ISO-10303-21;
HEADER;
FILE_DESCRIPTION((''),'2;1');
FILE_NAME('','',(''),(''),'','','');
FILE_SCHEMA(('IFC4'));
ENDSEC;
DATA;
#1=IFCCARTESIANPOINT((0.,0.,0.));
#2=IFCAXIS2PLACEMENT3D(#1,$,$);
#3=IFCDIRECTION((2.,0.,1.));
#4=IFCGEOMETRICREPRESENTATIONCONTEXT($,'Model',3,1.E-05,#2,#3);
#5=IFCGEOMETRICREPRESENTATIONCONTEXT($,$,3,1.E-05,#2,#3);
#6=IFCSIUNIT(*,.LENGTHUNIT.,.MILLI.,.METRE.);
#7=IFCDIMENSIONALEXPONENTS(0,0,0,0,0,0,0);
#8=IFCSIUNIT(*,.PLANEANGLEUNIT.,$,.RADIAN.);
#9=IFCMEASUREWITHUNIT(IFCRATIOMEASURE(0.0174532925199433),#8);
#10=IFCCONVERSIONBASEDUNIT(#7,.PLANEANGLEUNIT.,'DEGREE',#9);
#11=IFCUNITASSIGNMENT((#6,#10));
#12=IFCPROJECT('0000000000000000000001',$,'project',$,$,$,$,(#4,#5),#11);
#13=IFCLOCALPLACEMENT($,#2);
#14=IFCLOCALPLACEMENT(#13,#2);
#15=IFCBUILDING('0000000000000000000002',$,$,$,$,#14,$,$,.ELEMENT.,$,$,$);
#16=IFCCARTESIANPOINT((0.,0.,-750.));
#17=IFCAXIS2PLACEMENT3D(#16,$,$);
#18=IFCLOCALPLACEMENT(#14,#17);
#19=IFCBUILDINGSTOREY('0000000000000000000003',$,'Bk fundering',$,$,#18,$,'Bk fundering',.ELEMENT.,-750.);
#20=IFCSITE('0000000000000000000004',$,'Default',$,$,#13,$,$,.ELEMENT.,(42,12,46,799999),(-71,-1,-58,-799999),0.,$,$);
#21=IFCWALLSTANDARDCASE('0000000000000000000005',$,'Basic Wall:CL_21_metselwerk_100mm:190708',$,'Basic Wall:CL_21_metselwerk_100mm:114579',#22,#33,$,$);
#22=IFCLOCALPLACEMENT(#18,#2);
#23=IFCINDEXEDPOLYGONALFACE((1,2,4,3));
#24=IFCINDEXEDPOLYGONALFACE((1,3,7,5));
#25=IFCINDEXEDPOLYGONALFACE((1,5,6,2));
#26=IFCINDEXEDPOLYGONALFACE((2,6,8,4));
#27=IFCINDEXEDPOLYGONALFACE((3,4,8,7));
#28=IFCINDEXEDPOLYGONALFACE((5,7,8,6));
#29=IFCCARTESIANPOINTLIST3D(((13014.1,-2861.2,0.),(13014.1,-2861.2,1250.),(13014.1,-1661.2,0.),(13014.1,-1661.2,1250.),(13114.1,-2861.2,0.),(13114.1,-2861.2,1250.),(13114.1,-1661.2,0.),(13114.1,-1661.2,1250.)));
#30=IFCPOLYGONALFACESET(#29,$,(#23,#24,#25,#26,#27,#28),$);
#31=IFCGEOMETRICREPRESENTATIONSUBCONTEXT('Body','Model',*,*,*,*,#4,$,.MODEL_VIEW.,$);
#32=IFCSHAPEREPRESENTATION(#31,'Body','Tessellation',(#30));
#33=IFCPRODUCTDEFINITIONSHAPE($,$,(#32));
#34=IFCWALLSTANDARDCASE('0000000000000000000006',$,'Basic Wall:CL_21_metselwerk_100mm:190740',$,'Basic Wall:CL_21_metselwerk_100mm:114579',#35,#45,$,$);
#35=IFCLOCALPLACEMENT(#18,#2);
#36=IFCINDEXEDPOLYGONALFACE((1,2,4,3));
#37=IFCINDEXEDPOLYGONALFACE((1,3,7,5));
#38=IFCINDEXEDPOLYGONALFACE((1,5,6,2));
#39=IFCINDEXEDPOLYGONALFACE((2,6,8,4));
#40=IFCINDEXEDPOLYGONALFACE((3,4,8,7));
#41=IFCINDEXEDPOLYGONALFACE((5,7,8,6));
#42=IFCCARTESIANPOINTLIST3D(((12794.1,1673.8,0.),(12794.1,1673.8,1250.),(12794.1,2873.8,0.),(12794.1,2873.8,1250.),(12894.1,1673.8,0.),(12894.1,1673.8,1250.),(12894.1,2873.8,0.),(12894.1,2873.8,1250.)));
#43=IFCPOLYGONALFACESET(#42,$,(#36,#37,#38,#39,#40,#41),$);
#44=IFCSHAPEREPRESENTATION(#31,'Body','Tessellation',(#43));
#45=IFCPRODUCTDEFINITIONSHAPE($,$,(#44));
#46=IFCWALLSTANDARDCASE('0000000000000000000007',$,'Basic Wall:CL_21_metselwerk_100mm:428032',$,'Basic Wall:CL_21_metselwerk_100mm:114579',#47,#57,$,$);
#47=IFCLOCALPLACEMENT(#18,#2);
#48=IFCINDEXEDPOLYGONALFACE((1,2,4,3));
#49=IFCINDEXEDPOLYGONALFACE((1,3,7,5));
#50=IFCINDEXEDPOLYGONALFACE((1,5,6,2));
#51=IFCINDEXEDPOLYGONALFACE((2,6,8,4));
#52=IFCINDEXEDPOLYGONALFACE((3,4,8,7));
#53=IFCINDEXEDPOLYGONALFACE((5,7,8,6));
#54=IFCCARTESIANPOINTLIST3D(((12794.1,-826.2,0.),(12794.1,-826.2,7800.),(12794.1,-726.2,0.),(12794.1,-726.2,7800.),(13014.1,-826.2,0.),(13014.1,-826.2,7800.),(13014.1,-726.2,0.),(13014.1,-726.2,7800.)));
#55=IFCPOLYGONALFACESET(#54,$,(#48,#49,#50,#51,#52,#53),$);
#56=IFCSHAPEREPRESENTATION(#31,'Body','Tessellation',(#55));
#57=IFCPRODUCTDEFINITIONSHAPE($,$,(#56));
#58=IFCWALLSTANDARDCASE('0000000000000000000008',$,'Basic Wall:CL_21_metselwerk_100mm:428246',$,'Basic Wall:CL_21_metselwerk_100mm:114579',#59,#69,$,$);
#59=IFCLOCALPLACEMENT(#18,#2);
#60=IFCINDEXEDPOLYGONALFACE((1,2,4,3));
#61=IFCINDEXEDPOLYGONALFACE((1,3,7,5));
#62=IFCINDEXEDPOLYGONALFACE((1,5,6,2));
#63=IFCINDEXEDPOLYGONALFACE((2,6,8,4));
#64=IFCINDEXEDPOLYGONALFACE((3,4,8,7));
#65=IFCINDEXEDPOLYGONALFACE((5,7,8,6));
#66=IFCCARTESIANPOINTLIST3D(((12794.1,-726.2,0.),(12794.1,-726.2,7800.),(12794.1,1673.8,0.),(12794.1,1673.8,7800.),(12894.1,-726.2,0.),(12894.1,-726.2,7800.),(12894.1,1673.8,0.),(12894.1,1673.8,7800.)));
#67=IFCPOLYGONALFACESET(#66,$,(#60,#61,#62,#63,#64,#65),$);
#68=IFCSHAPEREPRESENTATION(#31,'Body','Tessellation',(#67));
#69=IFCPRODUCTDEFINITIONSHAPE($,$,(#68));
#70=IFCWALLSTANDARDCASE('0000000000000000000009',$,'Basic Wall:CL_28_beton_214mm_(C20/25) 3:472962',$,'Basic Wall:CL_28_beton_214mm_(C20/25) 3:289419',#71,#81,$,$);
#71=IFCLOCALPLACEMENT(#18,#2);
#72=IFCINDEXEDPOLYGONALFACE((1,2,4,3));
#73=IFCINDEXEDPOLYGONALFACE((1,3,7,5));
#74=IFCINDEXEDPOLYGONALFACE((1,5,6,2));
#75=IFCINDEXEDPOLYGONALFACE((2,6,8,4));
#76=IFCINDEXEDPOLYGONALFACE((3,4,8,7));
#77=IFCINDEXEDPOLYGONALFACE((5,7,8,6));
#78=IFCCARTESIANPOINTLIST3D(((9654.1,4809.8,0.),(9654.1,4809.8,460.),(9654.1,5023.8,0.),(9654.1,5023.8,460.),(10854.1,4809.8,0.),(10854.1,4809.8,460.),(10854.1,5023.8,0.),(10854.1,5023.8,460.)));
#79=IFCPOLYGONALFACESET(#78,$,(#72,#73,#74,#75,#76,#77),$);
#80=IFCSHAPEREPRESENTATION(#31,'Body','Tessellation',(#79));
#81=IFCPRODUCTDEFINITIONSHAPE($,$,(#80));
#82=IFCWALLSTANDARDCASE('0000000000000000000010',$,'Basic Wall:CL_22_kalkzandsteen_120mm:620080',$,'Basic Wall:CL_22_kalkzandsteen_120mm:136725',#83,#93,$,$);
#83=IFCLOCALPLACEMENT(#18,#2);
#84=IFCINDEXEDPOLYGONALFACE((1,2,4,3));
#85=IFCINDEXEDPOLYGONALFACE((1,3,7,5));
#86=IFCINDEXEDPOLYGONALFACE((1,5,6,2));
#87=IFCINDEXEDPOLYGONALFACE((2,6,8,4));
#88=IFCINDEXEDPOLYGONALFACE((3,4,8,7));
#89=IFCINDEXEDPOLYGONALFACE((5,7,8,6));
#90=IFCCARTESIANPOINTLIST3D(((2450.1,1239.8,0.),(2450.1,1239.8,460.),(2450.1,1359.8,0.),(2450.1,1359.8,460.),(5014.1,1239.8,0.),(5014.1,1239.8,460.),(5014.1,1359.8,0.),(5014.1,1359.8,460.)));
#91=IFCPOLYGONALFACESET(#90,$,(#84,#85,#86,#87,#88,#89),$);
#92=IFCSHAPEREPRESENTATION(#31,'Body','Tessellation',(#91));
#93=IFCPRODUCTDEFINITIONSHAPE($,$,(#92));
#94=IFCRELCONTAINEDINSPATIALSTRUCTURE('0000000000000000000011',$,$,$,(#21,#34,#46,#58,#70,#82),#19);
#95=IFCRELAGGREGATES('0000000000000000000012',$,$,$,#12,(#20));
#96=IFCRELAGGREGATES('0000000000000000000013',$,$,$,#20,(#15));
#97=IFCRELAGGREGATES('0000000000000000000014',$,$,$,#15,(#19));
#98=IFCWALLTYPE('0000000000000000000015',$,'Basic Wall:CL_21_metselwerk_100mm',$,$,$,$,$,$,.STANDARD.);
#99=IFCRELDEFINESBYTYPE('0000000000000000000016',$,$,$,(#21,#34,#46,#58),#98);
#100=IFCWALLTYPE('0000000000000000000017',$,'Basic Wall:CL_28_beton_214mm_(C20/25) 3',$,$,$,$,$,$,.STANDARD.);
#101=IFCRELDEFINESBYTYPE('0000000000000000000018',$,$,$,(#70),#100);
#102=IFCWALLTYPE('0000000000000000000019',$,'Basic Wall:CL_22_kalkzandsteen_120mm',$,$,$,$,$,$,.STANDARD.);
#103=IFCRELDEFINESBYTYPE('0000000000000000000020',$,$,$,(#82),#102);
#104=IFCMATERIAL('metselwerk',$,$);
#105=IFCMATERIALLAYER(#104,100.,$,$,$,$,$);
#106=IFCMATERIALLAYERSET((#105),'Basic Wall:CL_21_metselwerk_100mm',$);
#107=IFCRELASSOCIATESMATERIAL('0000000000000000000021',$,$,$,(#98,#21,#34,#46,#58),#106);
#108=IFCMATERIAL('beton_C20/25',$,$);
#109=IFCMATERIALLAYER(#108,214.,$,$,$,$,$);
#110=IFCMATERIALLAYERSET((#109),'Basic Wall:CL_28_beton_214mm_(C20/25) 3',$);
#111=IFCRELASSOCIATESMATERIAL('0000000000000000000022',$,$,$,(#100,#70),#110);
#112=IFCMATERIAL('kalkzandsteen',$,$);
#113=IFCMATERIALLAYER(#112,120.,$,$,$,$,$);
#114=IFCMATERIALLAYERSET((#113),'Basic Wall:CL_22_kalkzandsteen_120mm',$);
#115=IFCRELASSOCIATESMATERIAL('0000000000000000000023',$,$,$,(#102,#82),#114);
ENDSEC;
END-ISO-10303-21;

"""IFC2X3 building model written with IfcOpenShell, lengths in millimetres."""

from ifc_helpers import new_model, entity, si_unit, converted_unit, direction, frame, frame_2d, origin, place, context, subcontext, project, spatial, polyline, rectangle, extrude, clip, bounded_halfspace, material, layer, layer_set, layer_usage, type_object, element, save


model = new_model("IFC2X3")

# Units and contexts
model_context = context("Model", 3, precision=1e-05, world=origin(), true_north=direction((2.0, 0.0, 1.0)))
context_of_model = context(None, 3, precision=1e-05, world=origin(), true_north=direction((2.0, 0.0, 1.0)))
body_context = subcontext(model_context, "Body", "Model", "MODEL_VIEW")
ifc_project = project(units=[si_unit("LENGTHUNIT", "METRE", prefix="MILLI"), converted_unit("PLANEANGLEUNIT", "DEGREE", entity("IfcRatioMeasure", 0.0174532925199433), si_unit("PLANEANGLEUNIT", "RADIAN"), dimensions=[0, 0, 0, 0, 0, 0, 0])], contexts=[model_context, context_of_model])

# Site, building, storey
site_placement = place(None, origin())
site = spatial("IfcSite", under=ifc_project, at=site_placement, Name="Default", CompositionType="ELEMENT", RefLatitude=(42, 12, 46, 799999), RefLongitude=(-71, -1, -58, -799999), RefElevation=0.0)
building_placement = place(site_placement, origin())
building = spatial("IfcBuilding", under=site, at=building_placement, CompositionType="ELEMENT")
storey_placement = place(building_placement, frame((0.0, 0.0, -750.0)))
storey = spatial("IfcBuildingStorey", under=building, at=storey_placement, Name="Bk fundering", LongName="Bk fundering", CompositionType="ELEMENT", Elevation=-750.0)

# Shared definitions
ifc_material_1 = material(Name="kalkzandsteen")

# Walls
ifc_material_2 = material(Name="beton_C20/25")
ifc_material_3 = material(Name="metselwerk")
ifc_layer_1 = layer(ifc_material_3, 100.0)
ifc_layer_set_1 = layer_set([ifc_layer_1], Name="Basic Wall:CL_21_metselwerk_100mm")
wall_type_1 = type_object("IfcWallType", Name="Basic Wall:CL_21_metselwerk_100mm", PredefinedType="STANDARD", material=ifc_layer_set_1)
ifc_layer_usage_1 = layer_usage(ifc_layer_set_1, "AXIS2", "NEGATIVE", 50.0)
wall_1_placement = place(storey_placement, frame((13064.1, -2861.2, 0.0), z_axis=(0.0, 0.0, 1.0), x_axis=(0.0, 1.0, 0.0)))
element("IfcWallStandardCase", 1, at=wall_1_placement, inside=storey, type_object=wall_type_1, material=ifc_layer_usage_1, Name="Basic Wall:CL_21_metselwerk_100mm:190708", ObjectType="Basic Wall:CL_21_metselwerk_100mm:114579", context=body_context, shape_type="SweptSolid", body=[
    extrude(rectangle(XDim=1200.0, YDim=100.0, at=frame_2d((600.0, 0.0), x_axis=(-1.0, 0.0))), origin(), (0.0, 0.0, 1.0), 1250.0),
])
ifc_layer_usage_2 = layer_usage(ifc_layer_set_1, "AXIS2", "NEGATIVE", 50.0)
wall_2_placement = place(storey_placement, frame((12844.1, 1673.8, 0.0), z_axis=(0.0, 0.0, 1.0), x_axis=(0.0, 1.0, 0.0)))
element("IfcWallStandardCase", 2, at=wall_2_placement, inside=storey, type_object=wall_type_1, material=ifc_layer_usage_2, Name="Basic Wall:CL_21_metselwerk_100mm:190740", ObjectType="Basic Wall:CL_21_metselwerk_100mm:114579", context=body_context, shape_type="SweptSolid", body=[
    extrude(rectangle(XDim=1200.0, YDim=100.0, at=frame_2d((600.0, 0.0), x_axis=(-1.0, 0.0))), origin(), (0.0, 0.0, 1.0), 1250.0),
])
ifc_layer_usage_3 = layer_usage(ifc_layer_set_1, "AXIS2", "NEGATIVE", 50.0)
wall_3_placement = place(storey_placement, frame((13014.1, -776.2, 0.0), z_axis=(0.0, 0.0, 1.0), x_axis=(-1.0, 0.0, 0.0)))
element("IfcWallStandardCase", 3, at=wall_3_placement, inside=storey, type_object=wall_type_1, material=ifc_layer_usage_3, Name="Basic Wall:CL_21_metselwerk_100mm:428032", ObjectType="Basic Wall:CL_21_metselwerk_100mm:114579", context=body_context, shape_type="SweptSolid", body=[
    extrude(rectangle(XDim=220.0, YDim=100.0, at=frame_2d((110.0, 0.0), x_axis=(-1.0, 0.0))), origin(), (0.0, 0.0, 1.0), 7800.0),
])
ifc_layer_usage_4 = layer_usage(ifc_layer_set_1, "AXIS2", "NEGATIVE", 50.0)
wall_4_placement = place(storey_placement, frame((12844.1, -726.2, 0.0), z_axis=(0.0, 0.0, 1.0), x_axis=(0.0, 1.0, 0.0)))
element("IfcWallStandardCase", 4, at=wall_4_placement, inside=storey, type_object=wall_type_1, material=ifc_layer_usage_4, Name="Basic Wall:CL_21_metselwerk_100mm:428246", ObjectType="Basic Wall:CL_21_metselwerk_100mm:114579", context=body_context, shape_type="SweptSolid", body=[
    extrude(rectangle(XDim=2400.0, YDim=100.0, at=frame_2d((1200.0, 0.0), x_axis=(-1.0, 0.0))), origin(), (0.0, 0.0, 1.0), 7800.0),
])
ifc_layer_2 = layer(ifc_material_2, 214.0)
ifc_layer_set_2 = layer_set([ifc_layer_2], Name="Basic Wall:CL_28_beton_214mm_(C20/25) 3")
ifc_layer_usage_5 = layer_usage(ifc_layer_set_2, "AXIS2", "NEGATIVE", 107.0)
wall_type_2 = type_object("IfcWallType", Name="Basic Wall:CL_28_beton_214mm_(C20/25) 3", PredefinedType="STANDARD", material=ifc_layer_set_2)
wall_5_placement = place(storey_placement, frame((9654.1, 4916.8, 0.0)))
element("IfcWallStandardCase", 5, at=wall_5_placement, inside=storey, type_object=wall_type_2, material=ifc_layer_usage_5, Name="Basic Wall:CL_28_beton_214mm_(C20/25) 3:472962", ObjectType="Basic Wall:CL_28_beton_214mm_(C20/25) 3:289419", context=body_context, shape_type="Clipping", body=[
    clip(extrude(rectangle(XDim=1200.0, YDim=214.0, at=frame_2d((600.0, 0.0), x_axis=(-1.0, 0.0))), origin(), (0.0, 0.0, 1.0), 460.0), bounded_halfspace(frame((0.0, -107.0, 460.0), z_axis=(0.0, 0.0, -1.0), x_axis=(0.0, -1.0, 0.0)), True, frame((0.0, -107.0, 460.0)), polyline([(0.0, 0.0), (1200.0, 0.0), (1200.0, 214.0), (0.0, 214.0), (0.0, 0.0)]))),
])
ifc_layer_3 = layer(ifc_material_1, 120.0)
ifc_layer_set_3 = layer_set([ifc_layer_3], Name="Basic Wall:CL_22_kalkzandsteen_120mm")
ifc_layer_usage_6 = layer_usage(ifc_layer_set_3, "AXIS2", "NEGATIVE", 60.0)
wall_type_3 = type_object("IfcWallType", Name="Basic Wall:CL_22_kalkzandsteen_120mm", PredefinedType="STANDARD", material=ifc_layer_set_3)
wall_6_placement = place(storey_placement, frame((5014.1, 1299.8, 0.0), z_axis=(0.0, 0.0, 1.0), x_axis=(-1.0, 0.0, 0.0)))
element("IfcWallStandardCase", 6, at=wall_6_placement, inside=storey, type_object=wall_type_3, material=ifc_layer_usage_6, Name="Basic Wall:CL_22_kalkzandsteen_120mm:620080", ObjectType="Basic Wall:CL_22_kalkzandsteen_120mm:136725", context=body_context, shape_type="SweptSolid", body=[
    extrude(rectangle(XDim=2564.0, YDim=120.0, at=frame_2d((1282.0, 0.0), x_axis=(-1.0, 0.0))), origin(), (0.0, 0.0, 1.0), 460.0),
])

save(model, "model.ifc")
